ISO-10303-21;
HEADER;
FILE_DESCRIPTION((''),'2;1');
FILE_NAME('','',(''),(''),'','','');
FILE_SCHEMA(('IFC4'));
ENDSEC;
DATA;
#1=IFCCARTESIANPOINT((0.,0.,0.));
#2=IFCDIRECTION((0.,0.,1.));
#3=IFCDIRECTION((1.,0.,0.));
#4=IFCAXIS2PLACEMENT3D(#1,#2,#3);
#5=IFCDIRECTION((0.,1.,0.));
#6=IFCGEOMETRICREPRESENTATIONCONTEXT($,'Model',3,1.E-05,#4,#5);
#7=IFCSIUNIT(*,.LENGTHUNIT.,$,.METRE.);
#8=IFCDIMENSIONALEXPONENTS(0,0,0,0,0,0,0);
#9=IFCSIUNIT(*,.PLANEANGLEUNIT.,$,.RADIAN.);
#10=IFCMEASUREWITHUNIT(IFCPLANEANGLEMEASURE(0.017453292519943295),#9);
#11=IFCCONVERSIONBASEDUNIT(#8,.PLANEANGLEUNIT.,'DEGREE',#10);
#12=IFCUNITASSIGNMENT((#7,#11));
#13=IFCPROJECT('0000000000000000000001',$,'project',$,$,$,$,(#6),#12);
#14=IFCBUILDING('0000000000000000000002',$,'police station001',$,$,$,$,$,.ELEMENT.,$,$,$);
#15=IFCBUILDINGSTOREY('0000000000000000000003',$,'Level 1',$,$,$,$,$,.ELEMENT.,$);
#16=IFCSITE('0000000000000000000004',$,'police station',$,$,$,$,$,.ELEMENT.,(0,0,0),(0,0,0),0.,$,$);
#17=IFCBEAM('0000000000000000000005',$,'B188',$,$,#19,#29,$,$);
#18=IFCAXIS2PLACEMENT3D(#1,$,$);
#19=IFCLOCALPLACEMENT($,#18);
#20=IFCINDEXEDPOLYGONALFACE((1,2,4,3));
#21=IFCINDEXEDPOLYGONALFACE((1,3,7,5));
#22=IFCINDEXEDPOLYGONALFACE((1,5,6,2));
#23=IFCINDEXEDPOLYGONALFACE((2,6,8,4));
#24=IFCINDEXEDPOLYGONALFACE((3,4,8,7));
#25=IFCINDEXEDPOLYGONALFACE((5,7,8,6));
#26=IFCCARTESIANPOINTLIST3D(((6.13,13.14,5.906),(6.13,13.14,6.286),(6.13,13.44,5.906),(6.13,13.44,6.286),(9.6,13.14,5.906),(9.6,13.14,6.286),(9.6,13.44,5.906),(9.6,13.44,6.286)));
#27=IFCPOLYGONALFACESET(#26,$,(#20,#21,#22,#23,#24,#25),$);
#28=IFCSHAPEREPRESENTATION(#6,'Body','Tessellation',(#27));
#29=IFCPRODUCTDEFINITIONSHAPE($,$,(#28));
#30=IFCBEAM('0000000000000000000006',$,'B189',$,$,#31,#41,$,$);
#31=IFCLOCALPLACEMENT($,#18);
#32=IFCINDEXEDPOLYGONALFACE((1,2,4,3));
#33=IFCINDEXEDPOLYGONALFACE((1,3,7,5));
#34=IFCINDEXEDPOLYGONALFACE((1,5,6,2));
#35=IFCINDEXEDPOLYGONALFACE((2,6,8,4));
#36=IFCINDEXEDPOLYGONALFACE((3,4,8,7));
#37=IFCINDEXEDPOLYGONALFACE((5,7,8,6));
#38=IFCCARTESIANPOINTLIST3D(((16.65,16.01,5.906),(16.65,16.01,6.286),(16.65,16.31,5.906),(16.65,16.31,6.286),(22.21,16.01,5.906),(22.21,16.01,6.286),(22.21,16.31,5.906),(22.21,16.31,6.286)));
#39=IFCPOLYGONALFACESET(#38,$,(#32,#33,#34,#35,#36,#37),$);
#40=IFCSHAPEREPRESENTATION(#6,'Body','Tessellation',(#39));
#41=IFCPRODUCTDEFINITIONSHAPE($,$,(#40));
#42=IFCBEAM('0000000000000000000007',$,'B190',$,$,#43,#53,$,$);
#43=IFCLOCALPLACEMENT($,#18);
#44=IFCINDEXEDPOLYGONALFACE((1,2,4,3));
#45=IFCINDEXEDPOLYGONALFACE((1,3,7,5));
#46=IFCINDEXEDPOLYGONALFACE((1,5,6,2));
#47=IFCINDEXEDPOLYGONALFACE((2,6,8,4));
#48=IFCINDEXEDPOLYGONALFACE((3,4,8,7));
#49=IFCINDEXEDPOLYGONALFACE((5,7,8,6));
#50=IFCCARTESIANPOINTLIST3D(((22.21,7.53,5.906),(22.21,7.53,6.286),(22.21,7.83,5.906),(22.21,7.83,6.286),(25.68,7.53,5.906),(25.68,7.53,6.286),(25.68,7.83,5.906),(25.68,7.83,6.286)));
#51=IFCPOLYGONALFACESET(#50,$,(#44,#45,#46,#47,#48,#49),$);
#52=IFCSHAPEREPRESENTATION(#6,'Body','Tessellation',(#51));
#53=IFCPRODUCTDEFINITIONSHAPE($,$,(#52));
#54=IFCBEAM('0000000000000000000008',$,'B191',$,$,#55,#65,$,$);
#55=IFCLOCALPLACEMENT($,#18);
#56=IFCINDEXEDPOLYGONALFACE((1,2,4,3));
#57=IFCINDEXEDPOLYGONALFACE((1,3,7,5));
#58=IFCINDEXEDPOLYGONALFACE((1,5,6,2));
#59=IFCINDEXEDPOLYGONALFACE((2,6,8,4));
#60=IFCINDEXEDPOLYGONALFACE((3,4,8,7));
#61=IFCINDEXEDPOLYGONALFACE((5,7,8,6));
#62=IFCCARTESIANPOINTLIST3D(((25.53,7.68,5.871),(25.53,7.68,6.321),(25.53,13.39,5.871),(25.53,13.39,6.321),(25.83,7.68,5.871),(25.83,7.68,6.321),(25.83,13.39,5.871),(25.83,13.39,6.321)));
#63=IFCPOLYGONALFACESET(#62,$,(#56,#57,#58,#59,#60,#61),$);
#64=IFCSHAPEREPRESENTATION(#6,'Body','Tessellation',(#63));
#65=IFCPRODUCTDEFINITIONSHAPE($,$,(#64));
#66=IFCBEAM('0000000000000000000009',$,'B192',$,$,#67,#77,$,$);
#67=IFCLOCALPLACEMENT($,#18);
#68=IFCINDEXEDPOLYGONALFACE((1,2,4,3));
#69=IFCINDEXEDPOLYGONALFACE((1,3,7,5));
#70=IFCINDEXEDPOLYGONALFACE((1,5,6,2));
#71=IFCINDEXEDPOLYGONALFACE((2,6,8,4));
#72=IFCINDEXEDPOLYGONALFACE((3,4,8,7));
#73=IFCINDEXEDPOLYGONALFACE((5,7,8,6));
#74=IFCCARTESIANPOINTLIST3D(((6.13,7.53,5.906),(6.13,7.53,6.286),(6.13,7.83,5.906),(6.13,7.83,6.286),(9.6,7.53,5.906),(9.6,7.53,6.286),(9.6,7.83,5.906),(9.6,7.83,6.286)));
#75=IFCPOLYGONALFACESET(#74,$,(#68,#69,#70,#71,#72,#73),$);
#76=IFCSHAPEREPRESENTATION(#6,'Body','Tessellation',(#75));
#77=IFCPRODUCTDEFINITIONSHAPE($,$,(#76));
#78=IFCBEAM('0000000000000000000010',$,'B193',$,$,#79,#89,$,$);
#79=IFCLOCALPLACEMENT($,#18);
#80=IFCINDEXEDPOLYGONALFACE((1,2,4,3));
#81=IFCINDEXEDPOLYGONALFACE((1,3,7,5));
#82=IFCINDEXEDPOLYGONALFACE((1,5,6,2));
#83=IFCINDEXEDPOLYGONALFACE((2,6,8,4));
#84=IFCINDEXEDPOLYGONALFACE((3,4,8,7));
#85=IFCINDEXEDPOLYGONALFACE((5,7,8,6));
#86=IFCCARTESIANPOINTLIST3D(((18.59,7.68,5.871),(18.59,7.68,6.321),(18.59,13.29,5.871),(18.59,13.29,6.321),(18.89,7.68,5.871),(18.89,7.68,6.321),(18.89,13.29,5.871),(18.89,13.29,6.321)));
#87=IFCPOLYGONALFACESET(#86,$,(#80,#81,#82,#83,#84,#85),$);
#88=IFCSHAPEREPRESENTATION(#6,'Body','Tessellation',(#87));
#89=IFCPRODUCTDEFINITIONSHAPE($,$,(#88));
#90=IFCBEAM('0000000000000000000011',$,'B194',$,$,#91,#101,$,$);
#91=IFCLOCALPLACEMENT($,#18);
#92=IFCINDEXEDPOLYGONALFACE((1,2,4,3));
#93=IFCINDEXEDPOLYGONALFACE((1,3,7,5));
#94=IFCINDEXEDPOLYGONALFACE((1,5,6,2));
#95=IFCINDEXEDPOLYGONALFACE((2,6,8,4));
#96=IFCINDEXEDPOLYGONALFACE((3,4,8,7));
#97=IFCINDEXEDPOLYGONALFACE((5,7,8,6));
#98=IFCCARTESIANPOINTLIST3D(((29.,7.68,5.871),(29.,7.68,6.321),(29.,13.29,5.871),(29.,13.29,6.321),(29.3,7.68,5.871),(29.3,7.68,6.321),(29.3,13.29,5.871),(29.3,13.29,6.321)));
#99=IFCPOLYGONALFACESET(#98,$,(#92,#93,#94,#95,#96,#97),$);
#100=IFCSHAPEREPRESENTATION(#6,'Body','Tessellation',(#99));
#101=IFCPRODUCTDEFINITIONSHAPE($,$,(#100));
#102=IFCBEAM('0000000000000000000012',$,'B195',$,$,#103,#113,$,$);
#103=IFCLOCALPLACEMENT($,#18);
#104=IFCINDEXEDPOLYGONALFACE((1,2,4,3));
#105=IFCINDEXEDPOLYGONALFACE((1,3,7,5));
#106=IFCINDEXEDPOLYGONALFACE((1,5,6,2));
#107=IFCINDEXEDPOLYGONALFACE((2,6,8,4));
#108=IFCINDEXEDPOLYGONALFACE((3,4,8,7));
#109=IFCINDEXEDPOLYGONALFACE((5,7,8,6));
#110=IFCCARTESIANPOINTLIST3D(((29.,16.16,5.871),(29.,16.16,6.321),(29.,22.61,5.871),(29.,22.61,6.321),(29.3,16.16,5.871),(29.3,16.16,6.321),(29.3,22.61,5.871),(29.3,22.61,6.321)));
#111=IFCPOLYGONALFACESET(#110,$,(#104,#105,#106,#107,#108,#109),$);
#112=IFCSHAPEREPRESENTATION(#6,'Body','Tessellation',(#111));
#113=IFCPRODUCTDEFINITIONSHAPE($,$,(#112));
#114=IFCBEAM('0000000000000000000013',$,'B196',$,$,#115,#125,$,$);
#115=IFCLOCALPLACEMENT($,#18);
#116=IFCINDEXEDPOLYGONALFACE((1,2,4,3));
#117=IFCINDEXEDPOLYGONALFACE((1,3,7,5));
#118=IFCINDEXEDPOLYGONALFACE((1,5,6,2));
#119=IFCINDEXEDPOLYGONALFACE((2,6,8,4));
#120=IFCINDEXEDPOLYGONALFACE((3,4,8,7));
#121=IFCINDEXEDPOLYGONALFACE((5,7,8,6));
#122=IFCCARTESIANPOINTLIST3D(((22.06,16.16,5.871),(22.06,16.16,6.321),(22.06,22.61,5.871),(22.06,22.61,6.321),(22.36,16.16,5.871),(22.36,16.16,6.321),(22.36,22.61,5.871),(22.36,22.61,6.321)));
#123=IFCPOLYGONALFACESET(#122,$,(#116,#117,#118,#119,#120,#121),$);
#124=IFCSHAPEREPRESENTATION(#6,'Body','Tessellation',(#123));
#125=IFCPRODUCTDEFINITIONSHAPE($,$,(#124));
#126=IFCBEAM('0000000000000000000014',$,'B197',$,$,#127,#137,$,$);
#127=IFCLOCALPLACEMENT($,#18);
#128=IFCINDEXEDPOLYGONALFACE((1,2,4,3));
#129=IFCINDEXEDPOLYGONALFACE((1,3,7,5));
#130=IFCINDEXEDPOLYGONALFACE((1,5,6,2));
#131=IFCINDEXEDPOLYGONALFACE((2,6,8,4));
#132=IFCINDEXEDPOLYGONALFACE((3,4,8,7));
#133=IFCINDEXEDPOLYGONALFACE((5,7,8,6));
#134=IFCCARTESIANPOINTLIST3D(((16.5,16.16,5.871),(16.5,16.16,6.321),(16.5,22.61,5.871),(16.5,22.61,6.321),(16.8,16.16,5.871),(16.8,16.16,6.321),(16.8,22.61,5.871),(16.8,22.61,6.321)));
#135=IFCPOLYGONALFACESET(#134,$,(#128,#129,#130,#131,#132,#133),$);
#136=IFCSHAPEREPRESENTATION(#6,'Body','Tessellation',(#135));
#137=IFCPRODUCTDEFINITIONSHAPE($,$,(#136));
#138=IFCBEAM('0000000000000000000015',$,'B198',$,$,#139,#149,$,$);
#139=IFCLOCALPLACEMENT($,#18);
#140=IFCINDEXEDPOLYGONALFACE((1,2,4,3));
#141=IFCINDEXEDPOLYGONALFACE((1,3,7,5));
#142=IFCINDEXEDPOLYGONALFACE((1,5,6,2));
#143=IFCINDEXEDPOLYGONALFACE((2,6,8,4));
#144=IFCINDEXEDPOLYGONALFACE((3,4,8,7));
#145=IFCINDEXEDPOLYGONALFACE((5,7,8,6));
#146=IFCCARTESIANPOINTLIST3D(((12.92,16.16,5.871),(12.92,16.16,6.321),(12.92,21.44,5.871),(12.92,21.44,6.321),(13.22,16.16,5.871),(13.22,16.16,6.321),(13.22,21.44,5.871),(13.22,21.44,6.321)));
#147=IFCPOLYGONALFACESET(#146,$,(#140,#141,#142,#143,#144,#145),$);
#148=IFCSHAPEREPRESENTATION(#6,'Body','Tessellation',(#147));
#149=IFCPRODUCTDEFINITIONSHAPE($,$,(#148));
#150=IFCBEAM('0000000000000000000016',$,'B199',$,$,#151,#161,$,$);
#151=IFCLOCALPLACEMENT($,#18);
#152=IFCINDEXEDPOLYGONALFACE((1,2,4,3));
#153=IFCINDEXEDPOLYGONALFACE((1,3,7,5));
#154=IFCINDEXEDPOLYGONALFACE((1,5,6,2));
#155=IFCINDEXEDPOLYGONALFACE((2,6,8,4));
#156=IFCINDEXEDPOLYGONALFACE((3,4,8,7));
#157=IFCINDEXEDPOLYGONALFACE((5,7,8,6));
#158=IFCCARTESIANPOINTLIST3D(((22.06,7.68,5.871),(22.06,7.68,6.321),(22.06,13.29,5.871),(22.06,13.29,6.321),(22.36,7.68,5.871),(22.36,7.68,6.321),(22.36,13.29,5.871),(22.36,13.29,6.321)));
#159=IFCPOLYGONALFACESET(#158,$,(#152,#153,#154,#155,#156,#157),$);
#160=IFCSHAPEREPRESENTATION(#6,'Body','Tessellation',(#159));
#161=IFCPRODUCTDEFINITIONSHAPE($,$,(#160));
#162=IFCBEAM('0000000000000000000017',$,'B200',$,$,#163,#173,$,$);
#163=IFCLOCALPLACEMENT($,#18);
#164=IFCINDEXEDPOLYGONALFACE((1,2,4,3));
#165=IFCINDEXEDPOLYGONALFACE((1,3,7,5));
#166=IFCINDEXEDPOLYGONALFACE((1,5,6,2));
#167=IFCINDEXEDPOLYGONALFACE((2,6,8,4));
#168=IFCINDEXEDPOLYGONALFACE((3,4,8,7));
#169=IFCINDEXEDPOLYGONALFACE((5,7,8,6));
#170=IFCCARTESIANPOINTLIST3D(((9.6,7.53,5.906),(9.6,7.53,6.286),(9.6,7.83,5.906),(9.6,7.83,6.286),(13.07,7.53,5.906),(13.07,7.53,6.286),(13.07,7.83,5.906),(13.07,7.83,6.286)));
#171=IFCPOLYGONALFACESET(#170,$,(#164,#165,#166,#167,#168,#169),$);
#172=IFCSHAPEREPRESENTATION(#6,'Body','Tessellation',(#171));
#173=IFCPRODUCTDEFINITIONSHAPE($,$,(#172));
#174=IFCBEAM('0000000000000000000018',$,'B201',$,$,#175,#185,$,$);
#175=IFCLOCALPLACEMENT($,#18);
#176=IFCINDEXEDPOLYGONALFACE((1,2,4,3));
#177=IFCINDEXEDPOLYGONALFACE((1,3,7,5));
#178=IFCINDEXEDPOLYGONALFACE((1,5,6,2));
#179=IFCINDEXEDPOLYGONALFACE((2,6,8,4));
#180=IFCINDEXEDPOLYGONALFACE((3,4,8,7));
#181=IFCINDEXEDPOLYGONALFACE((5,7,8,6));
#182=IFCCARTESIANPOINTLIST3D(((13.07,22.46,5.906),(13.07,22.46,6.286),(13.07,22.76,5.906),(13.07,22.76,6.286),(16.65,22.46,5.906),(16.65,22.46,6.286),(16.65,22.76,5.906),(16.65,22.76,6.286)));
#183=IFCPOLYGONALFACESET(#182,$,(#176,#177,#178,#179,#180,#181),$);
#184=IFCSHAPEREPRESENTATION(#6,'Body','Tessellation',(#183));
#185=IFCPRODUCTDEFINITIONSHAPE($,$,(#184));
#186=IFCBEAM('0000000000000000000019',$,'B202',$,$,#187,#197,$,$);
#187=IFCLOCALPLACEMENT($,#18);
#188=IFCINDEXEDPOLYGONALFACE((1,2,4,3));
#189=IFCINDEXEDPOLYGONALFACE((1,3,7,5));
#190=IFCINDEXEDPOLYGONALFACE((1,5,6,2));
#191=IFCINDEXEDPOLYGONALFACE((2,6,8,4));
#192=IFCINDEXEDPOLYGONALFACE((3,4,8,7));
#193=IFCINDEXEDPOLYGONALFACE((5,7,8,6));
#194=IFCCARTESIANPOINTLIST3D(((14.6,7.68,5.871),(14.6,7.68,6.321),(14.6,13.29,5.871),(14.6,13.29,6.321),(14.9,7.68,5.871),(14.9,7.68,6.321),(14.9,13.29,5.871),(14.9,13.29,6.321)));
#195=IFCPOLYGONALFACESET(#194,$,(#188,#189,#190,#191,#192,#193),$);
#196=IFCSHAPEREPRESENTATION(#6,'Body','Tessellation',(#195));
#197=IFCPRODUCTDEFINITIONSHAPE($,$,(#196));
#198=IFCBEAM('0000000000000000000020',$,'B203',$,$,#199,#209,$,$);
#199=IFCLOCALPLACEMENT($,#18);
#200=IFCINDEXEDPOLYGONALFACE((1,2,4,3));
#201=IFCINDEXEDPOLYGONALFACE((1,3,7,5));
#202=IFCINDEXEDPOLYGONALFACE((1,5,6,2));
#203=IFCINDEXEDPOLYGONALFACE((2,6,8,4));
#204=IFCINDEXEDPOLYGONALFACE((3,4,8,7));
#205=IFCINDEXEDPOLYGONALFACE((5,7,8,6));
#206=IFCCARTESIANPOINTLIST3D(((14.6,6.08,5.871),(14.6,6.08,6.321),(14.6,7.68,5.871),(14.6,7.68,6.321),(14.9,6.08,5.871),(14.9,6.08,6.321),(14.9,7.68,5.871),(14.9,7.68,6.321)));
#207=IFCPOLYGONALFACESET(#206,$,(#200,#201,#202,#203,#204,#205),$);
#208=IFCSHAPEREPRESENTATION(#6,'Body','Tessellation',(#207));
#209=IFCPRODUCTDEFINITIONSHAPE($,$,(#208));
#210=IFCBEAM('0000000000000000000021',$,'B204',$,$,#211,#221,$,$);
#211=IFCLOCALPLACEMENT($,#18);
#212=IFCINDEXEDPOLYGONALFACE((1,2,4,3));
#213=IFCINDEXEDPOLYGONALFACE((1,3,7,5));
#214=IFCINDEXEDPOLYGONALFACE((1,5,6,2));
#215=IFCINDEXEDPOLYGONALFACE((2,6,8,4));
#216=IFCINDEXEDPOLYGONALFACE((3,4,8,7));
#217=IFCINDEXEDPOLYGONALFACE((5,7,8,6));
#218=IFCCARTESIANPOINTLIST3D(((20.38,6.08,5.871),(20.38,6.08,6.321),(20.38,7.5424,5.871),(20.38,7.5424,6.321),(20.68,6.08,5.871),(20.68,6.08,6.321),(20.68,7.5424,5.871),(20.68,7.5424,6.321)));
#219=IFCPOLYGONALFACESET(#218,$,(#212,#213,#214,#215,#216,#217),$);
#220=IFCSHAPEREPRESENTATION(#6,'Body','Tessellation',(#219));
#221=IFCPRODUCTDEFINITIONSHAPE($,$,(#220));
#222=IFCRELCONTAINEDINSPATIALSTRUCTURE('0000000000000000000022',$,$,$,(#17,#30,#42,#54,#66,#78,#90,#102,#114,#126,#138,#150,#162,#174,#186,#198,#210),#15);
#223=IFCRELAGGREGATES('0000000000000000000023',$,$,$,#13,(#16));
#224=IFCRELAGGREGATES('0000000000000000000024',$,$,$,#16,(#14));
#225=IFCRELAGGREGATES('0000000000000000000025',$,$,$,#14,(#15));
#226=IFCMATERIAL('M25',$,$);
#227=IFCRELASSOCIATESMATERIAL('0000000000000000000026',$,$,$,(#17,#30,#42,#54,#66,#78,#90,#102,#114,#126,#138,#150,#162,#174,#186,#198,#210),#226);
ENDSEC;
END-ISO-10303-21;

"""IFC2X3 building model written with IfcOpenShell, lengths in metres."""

from ifc_helpers import new_model, entity, si_unit, converted_unit, direction, frame, frame_2d, origin_with_axes, place, context, project, spatial, rectangle, extrude, material, element, save


model = new_model("IFC2X3")

# Units and contexts
model_context = context("Model", 3, precision=1e-05, world=origin_with_axes(), true_north=direction((0.0, 1.0, 0.0)))
ifc_project = project(units=[si_unit("LENGTHUNIT", "METRE"), converted_unit("PLANEANGLEUNIT", "DEGREE", entity("IfcPlaneAngleMeasure", 0.017453292519943295), si_unit("PLANEANGLEUNIT", "RADIAN"), dimensions=[0, 0, 0, 0, 0, 0, 0])], contexts=[model_context])

# Site, building, storey
site = spatial("IfcSite", under=ifc_project, Name="police station", CompositionType="ELEMENT", RefLatitude=(0, 0, 0), RefLongitude=(0, 0, 0), RefElevation=0.0)
building = spatial("IfcBuilding", under=site, Name="police station001", CompositionType="ELEMENT")
storey = spatial("IfcBuildingStorey", under=building, Name="Level 1", CompositionType="ELEMENT")

# Beams
ifc_material = material(Name="M25")
placement = place(None, origin_with_axes())
element("IfcBeam", 1, at=placement, inside=storey, material=ifc_material, Name="B188", context=model_context, shape_type="SweptSolid", body=[
    extrude(rectangle(XDim=0.3, YDim=0.38, at=frame_2d((0.0, 0.0), x_axis=(0.0, 1.0, 0.0))), frame((9.6, 13.29, 6.096), z_axis=(-1.0, 0.0, 0.0), x_axis=(0.0, 0.0, -1.0)), (0.0, 0.0, 1.0), 3.47),
])
element("IfcBeam", 2, at=placement, inside=storey, material=ifc_material, Name="B189", context=model_context, shape_type="SweptSolid", body=[
    extrude(rectangle(XDim=0.3, YDim=0.38, at=frame_2d((0.0, 0.0), x_axis=(0.0, 1.0, 0.0))), frame((22.21, 16.16, 6.096), z_axis=(-1.0, 0.0, 0.0), x_axis=(0.0, 0.0, -1.0)), (0.0, 0.0, 1.0), 5.56),
])
element("IfcBeam", 3, at=placement, inside=storey, material=ifc_material, Name="B190", context=model_context, shape_type="SweptSolid", body=[
    extrude(rectangle(XDim=0.3, YDim=0.38, at=frame_2d((0.0, 0.0), x_axis=(0.0, 1.0, 0.0))), frame((25.68, 7.68, 6.096), z_axis=(-1.0, 0.0, 0.0), x_axis=(0.0, 0.0, -1.0)), (0.0, 0.0, 1.0), 3.47),
])
element("IfcBeam", 4, at=placement, inside=storey, material=ifc_material, Name="B191", context=model_context, shape_type="SweptSolid", body=[
    extrude(rectangle(XDim=0.3, YDim=0.45, at=frame_2d((0.0, 0.0), x_axis=(0.0, 1.0, 0.0))), frame((25.68, 7.68, 6.096), z_axis=(0.0, 1.0, 0.0), x_axis=(0.0, 0.0, -1.0)), (0.0, 0.0, 1.0), 5.71),
])
element("IfcBeam", 5, at=placement, inside=storey, material=ifc_material, Name="B192", context=model_context, shape_type="SweptSolid", body=[
    extrude(rectangle(XDim=0.3, YDim=0.38, at=frame_2d((0.0, 0.0), x_axis=(0.0, 1.0, 0.0))), frame((6.13, 7.68, 6.096), z_axis=(1.0, 0.0, 0.0), x_axis=(0.0, 0.0, -1.0)), (0.0, 0.0, 1.0), 3.47),
])
element("IfcBeam", 6, at=placement, inside=storey, material=ifc_material, Name="B193", context=model_context, shape_type="SweptSolid", body=[
    extrude(rectangle(XDim=0.3, YDim=0.45, at=frame_2d((0.0, 0.0), x_axis=(0.0, 1.0, 0.0))), frame((18.74, 13.29, 6.096), z_axis=(0.0, -1.0, 0.0), x_axis=(0.0, 0.0, -1.0)), (0.0, 0.0, 1.0), 5.61),
])
element("IfcBeam", 7, at=placement, inside=storey, material=ifc_material, Name="B194", context=model_context, shape_type="SweptSolid", body=[
    extrude(rectangle(XDim=0.3, YDim=0.45, at=frame_2d((0.0, 0.0), x_axis=(0.0, 1.0, 0.0))), frame((29.15, 13.29, 6.096), z_axis=(0.0, -1.0, 0.0), x_axis=(0.0, 0.0, -1.0)), (0.0, 0.0, 1.0), 5.61),
])
element("IfcBeam", 8, at=placement, inside=storey, material=ifc_material, Name="B195", context=model_context, shape_type="SweptSolid", body=[
    extrude(rectangle(XDim=0.3, YDim=0.45, at=frame_2d((0.0, 0.0), x_axis=(0.0, 1.0, 0.0))), frame((29.15, 16.16, 6.096), z_axis=(0.0, 1.0, 0.0), x_axis=(0.0, 0.0, -1.0)), (0.0, 0.0, 1.0), 6.45),
])
element("IfcBeam", 9, at=placement, inside=storey, material=ifc_material, Name="B196", context=model_context, shape_type="SweptSolid", body=[
    extrude(rectangle(XDim=0.3, YDim=0.45, at=frame_2d((0.0, 0.0), x_axis=(0.0, 1.0, 0.0))), frame((22.21, 16.16, 6.096), z_axis=(0.0, 1.0, 0.0), x_axis=(0.0, 0.0, -1.0)), (0.0, 0.0, 1.0), 6.45),
])
element("IfcBeam", 10, at=placement, inside=storey, material=ifc_material, Name="B197", context=model_context, shape_type="SweptSolid", body=[
    extrude(rectangle(XDim=0.3, YDim=0.45, at=frame_2d((0.0, 0.0), x_axis=(0.0, 1.0, 0.0))), frame((16.65, 16.16, 6.096), z_axis=(0.0, 1.0, 0.0), x_axis=(0.0, 0.0, -1.0)), (0.0, 0.0, 1.0), 6.45),
])
element("IfcBeam", 11, at=placement, inside=storey, material=ifc_material, Name="B198", context=model_context, shape_type="SweptSolid", body=[
    extrude(rectangle(XDim=0.3, YDim=0.45, at=frame_2d((0.0, 0.0), x_axis=(0.0, 1.0, 0.0))), frame((13.07, 16.16, 6.096), z_axis=(0.0, 1.0, 0.0), x_axis=(0.0, 0.0, -1.0)), (0.0, 0.0, 1.0), 5.28),
])
element("IfcBeam", 12, at=placement, inside=storey, material=ifc_material, Name="B199", context=model_context, shape_type="SweptSolid", body=[
    extrude(rectangle(XDim=0.3, YDim=0.45, at=frame_2d((0.0, 0.0), x_axis=(0.0, 1.0, 0.0))), frame((22.21, 7.68, 6.096), z_axis=(0.0, 1.0, 0.0), x_axis=(0.0, 0.0, -1.0)), (0.0, 0.0, 1.0), 5.61),
])
element("IfcBeam", 13, at=placement, inside=storey, material=ifc_material, Name="B200", context=model_context, shape_type="SweptSolid", body=[
    extrude(rectangle(XDim=0.3, YDim=0.38, at=frame_2d((0.0, 0.0), x_axis=(0.0, 1.0, 0.0))), frame((9.6, 7.68, 6.096), z_axis=(1.0, 0.0, 0.0), x_axis=(0.0, 0.0, -1.0)), (0.0, 0.0, 1.0), 3.47),
])
element("IfcBeam", 14, at=placement, inside=storey, material=ifc_material, Name="B201", context=model_context, shape_type="SweptSolid", body=[
    extrude(rectangle(XDim=0.3, YDim=0.38, at=frame_2d((0.0, 0.0), x_axis=(0.0, 1.0, 0.0))), frame((13.07, 22.61, 6.096), z_axis=(1.0, 0.0, 0.0), x_axis=(0.0, 0.0, -1.0)), (0.0, 0.0, 1.0), 3.58),
])
element("IfcBeam", 15, at=placement, inside=storey, material=ifc_material, Name="B202", context=model_context, shape_type="SweptSolid", body=[
    extrude(rectangle(XDim=0.3, YDim=0.45, at=frame_2d((0.0, 0.0), x_axis=(0.0, 1.0, 0.0))), frame((14.75, 7.68, 6.096), z_axis=(0.0, 1.0, 0.0), x_axis=(0.0, 0.0, -1.0)), (0.0, 0.0, 1.0), 5.61),
])
element("IfcBeam", 16, at=placement, inside=storey, material=ifc_material, Name="B203", context=model_context, shape_type="SweptSolid", body=[
    extrude(rectangle(XDim=0.3, YDim=0.45, at=frame_2d((0.0, 0.0), x_axis=(0.0, 1.0, 0.0))), frame((14.75, 6.08, 6.096), z_axis=(0.0, 1.0, 0.0), x_axis=(0.0, 0.0, -1.0)), (0.0, 0.0, 1.0), 1.6),
])
element("IfcBeam", 17, at=placement, inside=storey, material=ifc_material, Name="B204", context=model_context, shape_type="SweptSolid", body=[
    extrude(rectangle(XDim=0.3, YDim=0.45, at=frame_2d((0.0, 0.0), x_axis=(0.0, 1.0, 0.0))), frame((20.53, 6.08, 6.096), z_axis=(0.0, 1.0, 0.0), x_axis=(0.0, 0.0, -1.0)), (0.0, 0.0, 1.0), 1.4624),
])

save(model, "model.ifc")
